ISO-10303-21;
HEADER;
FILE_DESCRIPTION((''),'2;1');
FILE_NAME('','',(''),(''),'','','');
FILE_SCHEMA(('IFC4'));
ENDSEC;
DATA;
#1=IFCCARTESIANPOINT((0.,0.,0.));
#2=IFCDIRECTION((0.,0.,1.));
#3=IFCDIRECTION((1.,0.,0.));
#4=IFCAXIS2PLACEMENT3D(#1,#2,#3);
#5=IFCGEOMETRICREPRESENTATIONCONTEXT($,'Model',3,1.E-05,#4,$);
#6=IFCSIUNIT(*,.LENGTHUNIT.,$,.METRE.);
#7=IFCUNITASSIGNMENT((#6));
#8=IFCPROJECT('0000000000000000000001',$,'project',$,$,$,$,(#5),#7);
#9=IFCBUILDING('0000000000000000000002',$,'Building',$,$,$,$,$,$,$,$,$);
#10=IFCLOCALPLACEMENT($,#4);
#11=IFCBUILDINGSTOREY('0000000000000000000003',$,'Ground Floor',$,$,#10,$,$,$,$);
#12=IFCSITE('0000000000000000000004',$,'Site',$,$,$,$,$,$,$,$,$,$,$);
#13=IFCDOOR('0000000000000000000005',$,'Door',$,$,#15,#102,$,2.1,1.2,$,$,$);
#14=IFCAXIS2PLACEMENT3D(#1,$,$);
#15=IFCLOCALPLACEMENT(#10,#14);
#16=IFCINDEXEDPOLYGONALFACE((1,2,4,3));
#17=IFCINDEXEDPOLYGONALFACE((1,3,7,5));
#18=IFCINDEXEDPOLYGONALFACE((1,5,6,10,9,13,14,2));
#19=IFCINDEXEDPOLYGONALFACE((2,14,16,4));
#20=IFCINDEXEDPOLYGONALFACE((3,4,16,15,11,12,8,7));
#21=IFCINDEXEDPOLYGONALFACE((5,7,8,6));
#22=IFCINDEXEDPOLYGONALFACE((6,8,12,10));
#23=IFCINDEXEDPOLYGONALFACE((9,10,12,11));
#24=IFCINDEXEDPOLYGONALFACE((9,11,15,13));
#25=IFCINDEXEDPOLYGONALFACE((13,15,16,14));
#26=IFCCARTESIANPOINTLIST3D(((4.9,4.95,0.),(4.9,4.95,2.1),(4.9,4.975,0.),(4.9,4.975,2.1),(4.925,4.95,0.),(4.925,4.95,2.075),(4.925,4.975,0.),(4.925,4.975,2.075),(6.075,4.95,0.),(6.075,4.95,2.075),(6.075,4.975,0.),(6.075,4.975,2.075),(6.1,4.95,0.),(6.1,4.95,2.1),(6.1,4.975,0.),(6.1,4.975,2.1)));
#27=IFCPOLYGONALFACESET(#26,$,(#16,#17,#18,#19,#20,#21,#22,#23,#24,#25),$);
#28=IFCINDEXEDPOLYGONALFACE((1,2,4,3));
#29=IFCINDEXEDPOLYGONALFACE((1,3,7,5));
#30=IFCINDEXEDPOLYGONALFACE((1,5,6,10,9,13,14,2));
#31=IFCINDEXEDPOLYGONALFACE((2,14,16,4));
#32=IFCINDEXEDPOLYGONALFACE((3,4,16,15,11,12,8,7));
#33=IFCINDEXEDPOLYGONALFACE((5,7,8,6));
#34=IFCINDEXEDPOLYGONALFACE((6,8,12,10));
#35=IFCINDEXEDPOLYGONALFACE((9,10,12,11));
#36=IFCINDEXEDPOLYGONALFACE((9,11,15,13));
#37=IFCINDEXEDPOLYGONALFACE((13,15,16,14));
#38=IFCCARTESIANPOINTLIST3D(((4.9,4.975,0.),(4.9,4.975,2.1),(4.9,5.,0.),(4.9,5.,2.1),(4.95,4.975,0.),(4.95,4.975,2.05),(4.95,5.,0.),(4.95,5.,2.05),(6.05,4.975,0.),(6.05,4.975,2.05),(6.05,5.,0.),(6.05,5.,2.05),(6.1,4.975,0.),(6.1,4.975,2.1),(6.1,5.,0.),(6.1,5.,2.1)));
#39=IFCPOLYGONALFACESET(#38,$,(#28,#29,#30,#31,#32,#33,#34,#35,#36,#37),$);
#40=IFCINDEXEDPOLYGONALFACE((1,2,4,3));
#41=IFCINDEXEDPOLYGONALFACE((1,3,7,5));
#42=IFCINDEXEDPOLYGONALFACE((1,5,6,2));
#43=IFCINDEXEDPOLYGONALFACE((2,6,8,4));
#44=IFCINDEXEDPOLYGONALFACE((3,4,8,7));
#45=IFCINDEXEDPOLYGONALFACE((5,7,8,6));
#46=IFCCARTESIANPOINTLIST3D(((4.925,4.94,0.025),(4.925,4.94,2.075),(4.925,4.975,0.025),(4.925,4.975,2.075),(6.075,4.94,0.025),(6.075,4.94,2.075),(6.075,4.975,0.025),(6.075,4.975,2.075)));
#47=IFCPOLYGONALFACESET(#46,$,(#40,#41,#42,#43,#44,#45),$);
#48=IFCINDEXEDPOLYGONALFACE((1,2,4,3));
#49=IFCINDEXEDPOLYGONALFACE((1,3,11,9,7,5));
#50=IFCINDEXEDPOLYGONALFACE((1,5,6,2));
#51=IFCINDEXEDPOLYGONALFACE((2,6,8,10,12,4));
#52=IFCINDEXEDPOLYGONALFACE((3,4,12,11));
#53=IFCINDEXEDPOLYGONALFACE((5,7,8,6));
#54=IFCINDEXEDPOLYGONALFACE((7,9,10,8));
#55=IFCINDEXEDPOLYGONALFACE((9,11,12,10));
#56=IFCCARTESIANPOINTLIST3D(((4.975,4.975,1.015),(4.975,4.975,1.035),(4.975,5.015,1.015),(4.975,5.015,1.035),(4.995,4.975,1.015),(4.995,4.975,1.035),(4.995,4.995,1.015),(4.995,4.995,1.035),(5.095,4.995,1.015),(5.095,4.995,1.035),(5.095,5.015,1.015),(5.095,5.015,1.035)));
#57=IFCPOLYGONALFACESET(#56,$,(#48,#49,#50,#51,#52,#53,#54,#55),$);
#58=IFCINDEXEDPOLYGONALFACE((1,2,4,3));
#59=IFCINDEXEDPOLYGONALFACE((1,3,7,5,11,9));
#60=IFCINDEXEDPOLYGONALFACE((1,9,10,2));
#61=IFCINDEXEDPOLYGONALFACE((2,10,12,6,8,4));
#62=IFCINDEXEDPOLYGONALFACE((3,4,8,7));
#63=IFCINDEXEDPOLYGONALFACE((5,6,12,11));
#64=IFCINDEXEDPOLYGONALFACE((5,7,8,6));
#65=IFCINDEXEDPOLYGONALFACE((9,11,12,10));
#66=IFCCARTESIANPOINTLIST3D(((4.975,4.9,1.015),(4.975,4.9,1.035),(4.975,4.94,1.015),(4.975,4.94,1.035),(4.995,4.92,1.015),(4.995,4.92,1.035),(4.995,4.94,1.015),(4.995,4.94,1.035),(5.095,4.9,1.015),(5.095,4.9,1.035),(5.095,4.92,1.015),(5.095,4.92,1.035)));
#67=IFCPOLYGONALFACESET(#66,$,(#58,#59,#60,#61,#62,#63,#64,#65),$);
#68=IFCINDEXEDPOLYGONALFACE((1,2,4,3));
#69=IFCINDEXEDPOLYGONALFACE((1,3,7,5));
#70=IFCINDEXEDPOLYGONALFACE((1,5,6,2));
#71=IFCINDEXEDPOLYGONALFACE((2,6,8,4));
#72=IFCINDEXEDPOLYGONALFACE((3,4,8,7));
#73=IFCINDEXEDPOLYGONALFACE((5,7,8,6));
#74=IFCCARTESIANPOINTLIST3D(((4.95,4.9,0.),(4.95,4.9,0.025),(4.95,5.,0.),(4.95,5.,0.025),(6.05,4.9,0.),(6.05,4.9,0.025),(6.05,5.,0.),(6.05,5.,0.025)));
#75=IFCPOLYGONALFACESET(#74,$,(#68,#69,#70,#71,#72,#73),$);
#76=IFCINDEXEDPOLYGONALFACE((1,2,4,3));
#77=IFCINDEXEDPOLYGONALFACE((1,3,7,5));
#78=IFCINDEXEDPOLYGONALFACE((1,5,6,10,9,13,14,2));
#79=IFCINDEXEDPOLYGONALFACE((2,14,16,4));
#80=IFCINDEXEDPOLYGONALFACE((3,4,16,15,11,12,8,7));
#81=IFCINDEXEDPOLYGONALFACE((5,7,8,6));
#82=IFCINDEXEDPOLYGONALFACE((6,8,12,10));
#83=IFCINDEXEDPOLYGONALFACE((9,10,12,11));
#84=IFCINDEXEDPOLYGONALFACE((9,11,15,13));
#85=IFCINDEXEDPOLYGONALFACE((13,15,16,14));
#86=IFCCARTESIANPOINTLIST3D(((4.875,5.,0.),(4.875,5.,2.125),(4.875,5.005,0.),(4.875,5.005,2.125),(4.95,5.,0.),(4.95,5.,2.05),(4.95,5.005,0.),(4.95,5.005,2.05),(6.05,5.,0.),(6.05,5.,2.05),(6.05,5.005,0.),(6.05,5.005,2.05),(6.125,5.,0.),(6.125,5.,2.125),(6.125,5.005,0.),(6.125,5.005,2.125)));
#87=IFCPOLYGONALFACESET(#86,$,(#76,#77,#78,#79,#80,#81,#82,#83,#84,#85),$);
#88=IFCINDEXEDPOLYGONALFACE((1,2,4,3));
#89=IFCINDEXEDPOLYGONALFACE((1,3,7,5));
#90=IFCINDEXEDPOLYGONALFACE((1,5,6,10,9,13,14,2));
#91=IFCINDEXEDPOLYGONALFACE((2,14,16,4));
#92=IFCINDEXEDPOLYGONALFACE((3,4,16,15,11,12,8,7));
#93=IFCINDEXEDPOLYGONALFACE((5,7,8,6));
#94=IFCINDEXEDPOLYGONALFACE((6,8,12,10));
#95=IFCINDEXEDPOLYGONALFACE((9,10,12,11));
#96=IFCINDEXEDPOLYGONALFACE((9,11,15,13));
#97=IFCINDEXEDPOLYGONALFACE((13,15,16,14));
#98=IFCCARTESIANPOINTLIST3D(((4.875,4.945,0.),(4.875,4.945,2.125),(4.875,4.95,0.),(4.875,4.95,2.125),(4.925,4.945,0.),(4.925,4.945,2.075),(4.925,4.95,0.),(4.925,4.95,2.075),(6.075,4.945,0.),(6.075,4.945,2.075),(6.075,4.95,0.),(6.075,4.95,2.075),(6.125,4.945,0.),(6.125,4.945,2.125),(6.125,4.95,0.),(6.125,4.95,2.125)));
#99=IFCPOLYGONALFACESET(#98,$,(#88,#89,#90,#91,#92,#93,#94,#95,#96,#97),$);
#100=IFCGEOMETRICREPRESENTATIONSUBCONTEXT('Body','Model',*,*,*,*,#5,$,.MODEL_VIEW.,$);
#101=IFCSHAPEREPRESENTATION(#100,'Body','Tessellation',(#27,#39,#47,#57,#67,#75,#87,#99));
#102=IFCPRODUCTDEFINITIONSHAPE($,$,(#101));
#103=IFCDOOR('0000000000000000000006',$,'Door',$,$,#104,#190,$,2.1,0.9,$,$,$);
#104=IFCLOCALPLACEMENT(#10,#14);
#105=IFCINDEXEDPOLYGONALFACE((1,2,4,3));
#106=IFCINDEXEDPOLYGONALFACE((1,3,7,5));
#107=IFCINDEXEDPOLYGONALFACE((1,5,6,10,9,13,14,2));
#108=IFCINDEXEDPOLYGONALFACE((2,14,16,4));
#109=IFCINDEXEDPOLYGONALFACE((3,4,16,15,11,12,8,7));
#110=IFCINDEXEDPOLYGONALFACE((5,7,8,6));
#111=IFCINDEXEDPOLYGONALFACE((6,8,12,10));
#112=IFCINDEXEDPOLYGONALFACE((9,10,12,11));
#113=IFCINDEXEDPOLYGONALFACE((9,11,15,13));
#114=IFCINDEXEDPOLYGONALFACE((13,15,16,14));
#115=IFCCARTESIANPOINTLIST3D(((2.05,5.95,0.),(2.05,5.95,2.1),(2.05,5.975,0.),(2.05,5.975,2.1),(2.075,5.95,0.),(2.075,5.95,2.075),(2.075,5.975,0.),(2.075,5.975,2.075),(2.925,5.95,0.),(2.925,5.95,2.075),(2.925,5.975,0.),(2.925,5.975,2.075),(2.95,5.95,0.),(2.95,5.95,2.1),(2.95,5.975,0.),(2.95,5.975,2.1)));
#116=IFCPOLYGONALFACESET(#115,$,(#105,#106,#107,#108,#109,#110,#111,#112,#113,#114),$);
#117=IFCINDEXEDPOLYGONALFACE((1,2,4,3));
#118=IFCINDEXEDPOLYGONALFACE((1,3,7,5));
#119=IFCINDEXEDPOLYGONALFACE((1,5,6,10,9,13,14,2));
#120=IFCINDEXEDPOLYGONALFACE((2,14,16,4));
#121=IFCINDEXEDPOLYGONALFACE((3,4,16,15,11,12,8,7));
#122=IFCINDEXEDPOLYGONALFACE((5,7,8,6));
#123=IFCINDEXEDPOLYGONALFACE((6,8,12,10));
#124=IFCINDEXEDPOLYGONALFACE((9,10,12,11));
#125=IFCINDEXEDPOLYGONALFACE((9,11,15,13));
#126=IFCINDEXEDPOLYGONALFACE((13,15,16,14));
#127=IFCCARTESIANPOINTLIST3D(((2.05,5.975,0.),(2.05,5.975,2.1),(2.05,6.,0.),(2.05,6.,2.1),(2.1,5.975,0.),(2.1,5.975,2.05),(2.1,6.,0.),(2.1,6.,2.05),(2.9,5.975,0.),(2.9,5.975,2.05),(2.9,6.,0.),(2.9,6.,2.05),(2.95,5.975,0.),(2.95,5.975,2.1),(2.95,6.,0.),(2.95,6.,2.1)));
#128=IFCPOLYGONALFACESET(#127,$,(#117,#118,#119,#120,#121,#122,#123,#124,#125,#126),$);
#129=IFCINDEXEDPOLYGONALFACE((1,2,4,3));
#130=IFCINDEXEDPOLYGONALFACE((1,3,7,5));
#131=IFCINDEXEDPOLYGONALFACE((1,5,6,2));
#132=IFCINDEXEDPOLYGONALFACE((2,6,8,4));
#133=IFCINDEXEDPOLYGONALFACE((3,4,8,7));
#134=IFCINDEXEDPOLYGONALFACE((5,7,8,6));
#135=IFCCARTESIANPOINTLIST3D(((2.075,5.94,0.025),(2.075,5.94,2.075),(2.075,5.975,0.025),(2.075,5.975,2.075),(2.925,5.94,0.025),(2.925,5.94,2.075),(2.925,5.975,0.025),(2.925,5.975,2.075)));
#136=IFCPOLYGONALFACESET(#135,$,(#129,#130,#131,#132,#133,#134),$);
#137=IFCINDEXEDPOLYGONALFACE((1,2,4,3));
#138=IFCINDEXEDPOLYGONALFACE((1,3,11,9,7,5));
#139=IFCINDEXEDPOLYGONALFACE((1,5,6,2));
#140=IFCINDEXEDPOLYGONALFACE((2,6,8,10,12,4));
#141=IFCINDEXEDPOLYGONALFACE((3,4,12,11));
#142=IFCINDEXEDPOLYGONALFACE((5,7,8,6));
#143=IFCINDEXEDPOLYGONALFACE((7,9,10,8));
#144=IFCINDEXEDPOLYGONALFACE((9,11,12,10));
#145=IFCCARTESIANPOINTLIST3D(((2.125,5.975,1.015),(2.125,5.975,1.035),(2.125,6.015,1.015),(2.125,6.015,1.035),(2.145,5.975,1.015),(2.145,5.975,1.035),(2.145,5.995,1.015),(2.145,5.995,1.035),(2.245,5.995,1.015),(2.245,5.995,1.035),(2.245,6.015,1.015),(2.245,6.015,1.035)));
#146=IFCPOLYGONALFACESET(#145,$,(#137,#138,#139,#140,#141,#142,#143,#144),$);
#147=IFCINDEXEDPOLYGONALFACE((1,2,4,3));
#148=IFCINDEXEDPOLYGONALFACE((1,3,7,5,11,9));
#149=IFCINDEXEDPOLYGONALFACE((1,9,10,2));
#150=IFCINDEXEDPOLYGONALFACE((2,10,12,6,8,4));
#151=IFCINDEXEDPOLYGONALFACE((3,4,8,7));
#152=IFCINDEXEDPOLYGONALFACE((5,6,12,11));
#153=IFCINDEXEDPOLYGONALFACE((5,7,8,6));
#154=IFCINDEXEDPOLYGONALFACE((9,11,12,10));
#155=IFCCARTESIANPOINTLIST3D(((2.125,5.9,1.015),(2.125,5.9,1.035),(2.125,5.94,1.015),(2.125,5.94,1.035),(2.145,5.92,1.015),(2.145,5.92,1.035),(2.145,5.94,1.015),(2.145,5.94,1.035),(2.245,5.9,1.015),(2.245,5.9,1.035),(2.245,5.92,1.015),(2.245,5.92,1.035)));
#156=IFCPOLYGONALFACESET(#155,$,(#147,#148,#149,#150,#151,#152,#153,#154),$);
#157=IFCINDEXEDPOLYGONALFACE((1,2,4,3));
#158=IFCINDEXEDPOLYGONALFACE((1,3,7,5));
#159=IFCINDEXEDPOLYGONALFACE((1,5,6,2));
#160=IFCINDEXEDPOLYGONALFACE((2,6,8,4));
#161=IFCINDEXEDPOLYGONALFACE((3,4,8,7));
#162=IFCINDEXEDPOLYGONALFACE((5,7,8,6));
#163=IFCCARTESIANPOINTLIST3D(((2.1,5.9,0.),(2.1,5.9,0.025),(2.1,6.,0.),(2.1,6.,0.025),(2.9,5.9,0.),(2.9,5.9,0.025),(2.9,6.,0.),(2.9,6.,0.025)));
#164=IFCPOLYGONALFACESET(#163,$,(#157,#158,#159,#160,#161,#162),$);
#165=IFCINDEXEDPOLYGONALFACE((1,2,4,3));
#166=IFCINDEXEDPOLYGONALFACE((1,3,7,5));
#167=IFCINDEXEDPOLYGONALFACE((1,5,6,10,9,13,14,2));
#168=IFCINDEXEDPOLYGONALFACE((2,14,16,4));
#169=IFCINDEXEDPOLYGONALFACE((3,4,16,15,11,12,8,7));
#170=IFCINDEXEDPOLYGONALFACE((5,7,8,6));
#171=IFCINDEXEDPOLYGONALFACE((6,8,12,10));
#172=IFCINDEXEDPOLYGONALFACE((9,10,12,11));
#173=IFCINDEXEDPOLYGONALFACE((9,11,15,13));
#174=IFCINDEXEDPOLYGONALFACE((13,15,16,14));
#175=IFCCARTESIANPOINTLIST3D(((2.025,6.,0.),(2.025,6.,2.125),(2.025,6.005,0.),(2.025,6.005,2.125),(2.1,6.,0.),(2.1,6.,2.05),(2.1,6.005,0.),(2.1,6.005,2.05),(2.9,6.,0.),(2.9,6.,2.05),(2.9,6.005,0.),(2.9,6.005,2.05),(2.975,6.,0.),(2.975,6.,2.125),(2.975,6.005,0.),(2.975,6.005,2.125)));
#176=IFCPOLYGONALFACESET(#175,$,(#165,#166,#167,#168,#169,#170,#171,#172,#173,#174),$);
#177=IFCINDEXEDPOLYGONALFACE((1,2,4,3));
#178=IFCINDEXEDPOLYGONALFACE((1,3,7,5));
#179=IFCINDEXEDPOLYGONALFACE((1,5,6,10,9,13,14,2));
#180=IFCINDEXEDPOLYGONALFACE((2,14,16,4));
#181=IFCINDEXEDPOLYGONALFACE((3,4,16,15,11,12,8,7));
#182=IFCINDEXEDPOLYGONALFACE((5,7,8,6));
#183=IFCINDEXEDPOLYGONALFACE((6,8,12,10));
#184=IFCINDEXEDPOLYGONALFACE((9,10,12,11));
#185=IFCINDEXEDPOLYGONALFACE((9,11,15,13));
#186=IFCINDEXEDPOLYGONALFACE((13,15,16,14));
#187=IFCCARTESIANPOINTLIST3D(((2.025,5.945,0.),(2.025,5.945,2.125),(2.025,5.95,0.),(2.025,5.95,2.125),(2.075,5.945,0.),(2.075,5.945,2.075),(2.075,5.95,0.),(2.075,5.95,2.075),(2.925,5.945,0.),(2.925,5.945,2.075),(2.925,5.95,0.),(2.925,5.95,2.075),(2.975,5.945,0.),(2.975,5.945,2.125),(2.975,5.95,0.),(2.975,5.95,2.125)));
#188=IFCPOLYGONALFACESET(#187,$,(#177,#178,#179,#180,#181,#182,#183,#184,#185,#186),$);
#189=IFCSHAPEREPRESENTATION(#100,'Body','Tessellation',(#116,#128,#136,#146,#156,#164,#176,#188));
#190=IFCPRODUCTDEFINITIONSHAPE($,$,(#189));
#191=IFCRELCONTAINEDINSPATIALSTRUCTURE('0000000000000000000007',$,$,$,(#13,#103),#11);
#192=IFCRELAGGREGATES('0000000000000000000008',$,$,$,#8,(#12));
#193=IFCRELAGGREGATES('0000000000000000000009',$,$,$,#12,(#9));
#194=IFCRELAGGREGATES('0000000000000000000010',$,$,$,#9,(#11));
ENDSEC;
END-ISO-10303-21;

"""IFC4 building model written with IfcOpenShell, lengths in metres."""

from ifc_helpers import new_model, si_unit, frame, origin_with_axes, place, context, subcontext, project, spatial, line, indexed_curve, outline, extrude, element, save


model = new_model("IFC4")

# Units and contexts
model_context = context("Model", 3, precision=1e-05, world=origin_with_axes())
body_context = subcontext(model_context, "Body", "Model", "MODEL_VIEW")
ifc_project = project(units=[si_unit("LENGTHUNIT", "METRE")], contexts=[model_context])

# Site, building, storey
site = spatial("IfcSite", under=ifc_project, Name="Site")
building = spatial("IfcBuilding", under=site, Name="Building")
storey_placement = place(None, origin_with_axes())
storey = spatial("IfcBuildingStorey", under=building, at=storey_placement, Name="Ground Floor")

# Doors
door_1_placement = place(storey_placement, frame((6.1, 5.0, 0.0), z_axis=(0.0, 0.0, 1.0), x_axis=(-1.0, 0.0, 0.0)))
element("IfcDoor", 1, at=door_1_placement, inside=storey, Name="Door", OverallHeight=2.1, OverallWidth=1.2, context=body_context, shape_type="SweptSolid", body=[
    extrude(outline(indexed_curve([(0.0, 0.0), (0.0, 2.1), (1.2, 2.1), (1.2, 0.0), (1.175, 0.0), (1.175, 2.075), (0.025, 2.075), (0.025, 0.0)], segments=[line(1, 2, 3, 4, 5, 6, 7, 8, 1)])), frame((0.0, 0.025, 0.0), z_axis=(0.0, -1.0, 0.0), x_axis=(1.0, 0.0, 0.0)), (0.0, 0.0, -1.0), 0.025),
    extrude(outline(indexed_curve([(0.0, 0.0), (0.0, 2.1), (1.2, 2.1), (1.2, 0.0), (1.15, 0.0), (1.15, 2.05), (0.05, 2.05), (0.05, 0.0)], segments=[line(1, 2, 3, 4, 5, 6, 7, 8, 1)])), frame((0.0, 0.0, 0.0), z_axis=(0.0, -1.0, 0.0), x_axis=(1.0, 0.0, 0.0)), (0.0, 0.0, -1.0), 0.025),
    extrude(outline(indexed_curve([(0.0, 0.0), (1.15, 0.0), (1.15, 0.035), (0.0, 0.035)], segments=[line(1, 2, 3, 4, 1)])), frame((0.025, 0.025, 0.025), z_axis=(0.0, 0.0, 1.0), x_axis=(1.0, 0.0, 0.0)), (0.0, 0.0, 1.0), 2.05),
    extrude(outline(indexed_curve([(0.0, 0.0), (0.0, -0.04), (-0.12, -0.04), (-0.12, -0.02), (-0.02, -0.02), (-0.02, 0.0)], segments=[line(1, 2, 3, 4, 5, 6, 1)])), frame((1.125, 0.025, 1.015), z_axis=(0.0, 0.0, 1.0), x_axis=(1.0, 0.0, 0.0)), (0.0, 0.0, 1.0), 0.02),
    extrude(outline(indexed_curve([(0.0, 0.0), (0.0, 0.04), (-0.12, 0.04), (-0.12, 0.02), (-0.02, 0.02), (-0.02, 0.0)], segments=[line(1, 2, 3, 4, 5, 6, 1)])), frame((1.125, 0.06, 1.015), z_axis=(0.0, 0.0, 1.0), x_axis=(1.0, 0.0, 0.0)), (0.0, 0.0, 1.0), 0.02),
    extrude(outline(indexed_curve([(0.0, 0.0), (1.1, 0.0), (1.1, 0.1), (0.0, 0.1)], segments=[line(1, 2, 3, 4, 1)])), frame((0.05, 0.0, 0.0), z_axis=(0.0, 0.0, 1.0), x_axis=(1.0, 0.0, 0.0)), (0.0, 0.0, 1.0), 0.025),
    extrude(outline(indexed_curve([(0.0, 0.0), (0.0, 2.125), (1.25, 2.125), (1.25, 0.0), (1.175, 0.0), (1.175, 2.05), (0.075, 2.05), (0.075, 0.0)], segments=[line(1, 2, 3, 4, 5, 6, 7, 8, 1)])), frame((-0.025, -0.005, 0.0), z_axis=(0.0, -1.0, 0.0), x_axis=(1.0, 0.0, 0.0)), (0.0, 0.0, -1.0), 0.005),
    extrude(outline(indexed_curve([(0.0, 0.0), (0.0, 2.125), (1.25, 2.125), (1.25, 0.0), (1.2, 0.0), (1.2, 2.075), (0.05, 2.075), (0.05, 0.0)], segments=[line(1, 2, 3, 4, 5, 6, 7, 8, 1)])), frame((-0.025, 0.05, 0.0), z_axis=(0.0, -1.0, 0.0), x_axis=(1.0, 0.0, 0.0)), (0.0, 0.0, -1.0), 0.005),
])
door_2_placement = place(storey_placement, frame((2.95, 6.0, 0.0), z_axis=(0.0, 0.0, 1.0), x_axis=(-1.0, 0.0, 0.0)))
element("IfcDoor", 2, at=door_2_placement, inside=storey, Name="Door", OverallHeight=2.1, OverallWidth=0.9, context=body_context, shape_type="SweptSolid", body=[
    extrude(outline(indexed_curve([(0.0, 0.0), (0.0, 2.1), (0.9, 2.1), (0.9, 0.0), (0.875, 0.0), (0.875, 2.075), (0.025, 2.075), (0.025, 0.0)], segments=[line(1, 2, 3, 4, 5, 6, 7, 8, 1)])), frame((0.0, 0.025, 0.0), z_axis=(0.0, -1.0, 0.0), x_axis=(1.0, 0.0, 0.0)), (0.0, 0.0, -1.0), 0.025),
    extrude(outline(indexed_curve([(0.0, 0.0), (0.0, 2.1), (0.9, 2.1), (0.9, 0.0), (0.85, 0.0), (0.85, 2.05), (0.05, 2.05), (0.05, 0.0)], segments=[line(1, 2, 3, 4, 5, 6, 7, 8, 1)])), frame((0.0, 0.0, 0.0), z_axis=(0.0, -1.0, 0.0), x_axis=(1.0, 0.0, 0.0)), (0.0, 0.0, -1.0), 0.025),
    extrude(outline(indexed_curve([(0.0, 0.0), (0.85, 0.0), (0.85, 0.035), (0.0, 0.035)], segments=[line(1, 2, 3, 4, 1)])), frame((0.025, 0.025, 0.025), z_axis=(0.0, 0.0, 1.0), x_axis=(1.0, 0.0, 0.0)), (0.0, 0.0, 1.0), 2.05),
    extrude(outline(indexed_curve([(0.0, 0.0), (0.0, -0.04), (-0.12, -0.04), (-0.12, -0.02), (-0.02, -0.02), (-0.02, 0.0)], segments=[line(1, 2, 3, 4, 5, 6, 1)])), frame((0.825, 0.025, 1.015), z_axis=(0.0, 0.0, 1.0), x_axis=(1.0, 0.0, 0.0)), (0.0, 0.0, 1.0), 0.02),
    extrude(outline(indexed_curve([(0.0, 0.0), (0.0, 0.04), (-0.12, 0.04), (-0.12, 0.02), (-0.02, 0.02), (-0.02, 0.0)], segments=[line(1, 2, 3, 4, 5, 6, 1)])), frame((0.825, 0.06, 1.015), z_axis=(0.0, 0.0, 1.0), x_axis=(1.0, 0.0, 0.0)), (0.0, 0.0, 1.0), 0.02),
    extrude(outline(indexed_curve([(0.0, 0.0), (0.8, 0.0), (0.8, 0.1), (0.0, 0.1)], segments=[line(1, 2, 3, 4, 1)])), frame((0.05, 0.0, 0.0), z_axis=(0.0, 0.0, 1.0), x_axis=(1.0, 0.0, 0.0)), (0.0, 0.0, 1.0), 0.025),
    extrude(outline(indexed_curve([(0.0, 0.0), (0.0, 2.125), (0.95, 2.125), (0.95, 0.0), (0.875, 0.0), (0.875, 2.05), (0.075, 2.05), (0.075, 0.0)], segments=[line(1, 2, 3, 4, 5, 6, 7, 8, 1)])), frame((-0.025, -0.005, 0.0), z_axis=(0.0, -1.0, 0.0), x_axis=(1.0, 0.0, 0.0)), (0.0, 0.0, -1.0), 0.005),
    extrude(outline(indexed_curve([(0.0, 0.0), (0.0, 2.125), (0.95, 2.125), (0.95, 0.0), (0.9, 0.0), (0.9, 2.075), (0.05, 2.075), (0.05, 0.0)], segments=[line(1, 2, 3, 4, 5, 6, 7, 8, 1)])), frame((-0.025, 0.05, 0.0), z_axis=(0.0, -1.0, 0.0), x_axis=(1.0, 0.0, 0.0)), (0.0, 0.0, -1.0), 0.005),
])

save(model, "model.ifc")
